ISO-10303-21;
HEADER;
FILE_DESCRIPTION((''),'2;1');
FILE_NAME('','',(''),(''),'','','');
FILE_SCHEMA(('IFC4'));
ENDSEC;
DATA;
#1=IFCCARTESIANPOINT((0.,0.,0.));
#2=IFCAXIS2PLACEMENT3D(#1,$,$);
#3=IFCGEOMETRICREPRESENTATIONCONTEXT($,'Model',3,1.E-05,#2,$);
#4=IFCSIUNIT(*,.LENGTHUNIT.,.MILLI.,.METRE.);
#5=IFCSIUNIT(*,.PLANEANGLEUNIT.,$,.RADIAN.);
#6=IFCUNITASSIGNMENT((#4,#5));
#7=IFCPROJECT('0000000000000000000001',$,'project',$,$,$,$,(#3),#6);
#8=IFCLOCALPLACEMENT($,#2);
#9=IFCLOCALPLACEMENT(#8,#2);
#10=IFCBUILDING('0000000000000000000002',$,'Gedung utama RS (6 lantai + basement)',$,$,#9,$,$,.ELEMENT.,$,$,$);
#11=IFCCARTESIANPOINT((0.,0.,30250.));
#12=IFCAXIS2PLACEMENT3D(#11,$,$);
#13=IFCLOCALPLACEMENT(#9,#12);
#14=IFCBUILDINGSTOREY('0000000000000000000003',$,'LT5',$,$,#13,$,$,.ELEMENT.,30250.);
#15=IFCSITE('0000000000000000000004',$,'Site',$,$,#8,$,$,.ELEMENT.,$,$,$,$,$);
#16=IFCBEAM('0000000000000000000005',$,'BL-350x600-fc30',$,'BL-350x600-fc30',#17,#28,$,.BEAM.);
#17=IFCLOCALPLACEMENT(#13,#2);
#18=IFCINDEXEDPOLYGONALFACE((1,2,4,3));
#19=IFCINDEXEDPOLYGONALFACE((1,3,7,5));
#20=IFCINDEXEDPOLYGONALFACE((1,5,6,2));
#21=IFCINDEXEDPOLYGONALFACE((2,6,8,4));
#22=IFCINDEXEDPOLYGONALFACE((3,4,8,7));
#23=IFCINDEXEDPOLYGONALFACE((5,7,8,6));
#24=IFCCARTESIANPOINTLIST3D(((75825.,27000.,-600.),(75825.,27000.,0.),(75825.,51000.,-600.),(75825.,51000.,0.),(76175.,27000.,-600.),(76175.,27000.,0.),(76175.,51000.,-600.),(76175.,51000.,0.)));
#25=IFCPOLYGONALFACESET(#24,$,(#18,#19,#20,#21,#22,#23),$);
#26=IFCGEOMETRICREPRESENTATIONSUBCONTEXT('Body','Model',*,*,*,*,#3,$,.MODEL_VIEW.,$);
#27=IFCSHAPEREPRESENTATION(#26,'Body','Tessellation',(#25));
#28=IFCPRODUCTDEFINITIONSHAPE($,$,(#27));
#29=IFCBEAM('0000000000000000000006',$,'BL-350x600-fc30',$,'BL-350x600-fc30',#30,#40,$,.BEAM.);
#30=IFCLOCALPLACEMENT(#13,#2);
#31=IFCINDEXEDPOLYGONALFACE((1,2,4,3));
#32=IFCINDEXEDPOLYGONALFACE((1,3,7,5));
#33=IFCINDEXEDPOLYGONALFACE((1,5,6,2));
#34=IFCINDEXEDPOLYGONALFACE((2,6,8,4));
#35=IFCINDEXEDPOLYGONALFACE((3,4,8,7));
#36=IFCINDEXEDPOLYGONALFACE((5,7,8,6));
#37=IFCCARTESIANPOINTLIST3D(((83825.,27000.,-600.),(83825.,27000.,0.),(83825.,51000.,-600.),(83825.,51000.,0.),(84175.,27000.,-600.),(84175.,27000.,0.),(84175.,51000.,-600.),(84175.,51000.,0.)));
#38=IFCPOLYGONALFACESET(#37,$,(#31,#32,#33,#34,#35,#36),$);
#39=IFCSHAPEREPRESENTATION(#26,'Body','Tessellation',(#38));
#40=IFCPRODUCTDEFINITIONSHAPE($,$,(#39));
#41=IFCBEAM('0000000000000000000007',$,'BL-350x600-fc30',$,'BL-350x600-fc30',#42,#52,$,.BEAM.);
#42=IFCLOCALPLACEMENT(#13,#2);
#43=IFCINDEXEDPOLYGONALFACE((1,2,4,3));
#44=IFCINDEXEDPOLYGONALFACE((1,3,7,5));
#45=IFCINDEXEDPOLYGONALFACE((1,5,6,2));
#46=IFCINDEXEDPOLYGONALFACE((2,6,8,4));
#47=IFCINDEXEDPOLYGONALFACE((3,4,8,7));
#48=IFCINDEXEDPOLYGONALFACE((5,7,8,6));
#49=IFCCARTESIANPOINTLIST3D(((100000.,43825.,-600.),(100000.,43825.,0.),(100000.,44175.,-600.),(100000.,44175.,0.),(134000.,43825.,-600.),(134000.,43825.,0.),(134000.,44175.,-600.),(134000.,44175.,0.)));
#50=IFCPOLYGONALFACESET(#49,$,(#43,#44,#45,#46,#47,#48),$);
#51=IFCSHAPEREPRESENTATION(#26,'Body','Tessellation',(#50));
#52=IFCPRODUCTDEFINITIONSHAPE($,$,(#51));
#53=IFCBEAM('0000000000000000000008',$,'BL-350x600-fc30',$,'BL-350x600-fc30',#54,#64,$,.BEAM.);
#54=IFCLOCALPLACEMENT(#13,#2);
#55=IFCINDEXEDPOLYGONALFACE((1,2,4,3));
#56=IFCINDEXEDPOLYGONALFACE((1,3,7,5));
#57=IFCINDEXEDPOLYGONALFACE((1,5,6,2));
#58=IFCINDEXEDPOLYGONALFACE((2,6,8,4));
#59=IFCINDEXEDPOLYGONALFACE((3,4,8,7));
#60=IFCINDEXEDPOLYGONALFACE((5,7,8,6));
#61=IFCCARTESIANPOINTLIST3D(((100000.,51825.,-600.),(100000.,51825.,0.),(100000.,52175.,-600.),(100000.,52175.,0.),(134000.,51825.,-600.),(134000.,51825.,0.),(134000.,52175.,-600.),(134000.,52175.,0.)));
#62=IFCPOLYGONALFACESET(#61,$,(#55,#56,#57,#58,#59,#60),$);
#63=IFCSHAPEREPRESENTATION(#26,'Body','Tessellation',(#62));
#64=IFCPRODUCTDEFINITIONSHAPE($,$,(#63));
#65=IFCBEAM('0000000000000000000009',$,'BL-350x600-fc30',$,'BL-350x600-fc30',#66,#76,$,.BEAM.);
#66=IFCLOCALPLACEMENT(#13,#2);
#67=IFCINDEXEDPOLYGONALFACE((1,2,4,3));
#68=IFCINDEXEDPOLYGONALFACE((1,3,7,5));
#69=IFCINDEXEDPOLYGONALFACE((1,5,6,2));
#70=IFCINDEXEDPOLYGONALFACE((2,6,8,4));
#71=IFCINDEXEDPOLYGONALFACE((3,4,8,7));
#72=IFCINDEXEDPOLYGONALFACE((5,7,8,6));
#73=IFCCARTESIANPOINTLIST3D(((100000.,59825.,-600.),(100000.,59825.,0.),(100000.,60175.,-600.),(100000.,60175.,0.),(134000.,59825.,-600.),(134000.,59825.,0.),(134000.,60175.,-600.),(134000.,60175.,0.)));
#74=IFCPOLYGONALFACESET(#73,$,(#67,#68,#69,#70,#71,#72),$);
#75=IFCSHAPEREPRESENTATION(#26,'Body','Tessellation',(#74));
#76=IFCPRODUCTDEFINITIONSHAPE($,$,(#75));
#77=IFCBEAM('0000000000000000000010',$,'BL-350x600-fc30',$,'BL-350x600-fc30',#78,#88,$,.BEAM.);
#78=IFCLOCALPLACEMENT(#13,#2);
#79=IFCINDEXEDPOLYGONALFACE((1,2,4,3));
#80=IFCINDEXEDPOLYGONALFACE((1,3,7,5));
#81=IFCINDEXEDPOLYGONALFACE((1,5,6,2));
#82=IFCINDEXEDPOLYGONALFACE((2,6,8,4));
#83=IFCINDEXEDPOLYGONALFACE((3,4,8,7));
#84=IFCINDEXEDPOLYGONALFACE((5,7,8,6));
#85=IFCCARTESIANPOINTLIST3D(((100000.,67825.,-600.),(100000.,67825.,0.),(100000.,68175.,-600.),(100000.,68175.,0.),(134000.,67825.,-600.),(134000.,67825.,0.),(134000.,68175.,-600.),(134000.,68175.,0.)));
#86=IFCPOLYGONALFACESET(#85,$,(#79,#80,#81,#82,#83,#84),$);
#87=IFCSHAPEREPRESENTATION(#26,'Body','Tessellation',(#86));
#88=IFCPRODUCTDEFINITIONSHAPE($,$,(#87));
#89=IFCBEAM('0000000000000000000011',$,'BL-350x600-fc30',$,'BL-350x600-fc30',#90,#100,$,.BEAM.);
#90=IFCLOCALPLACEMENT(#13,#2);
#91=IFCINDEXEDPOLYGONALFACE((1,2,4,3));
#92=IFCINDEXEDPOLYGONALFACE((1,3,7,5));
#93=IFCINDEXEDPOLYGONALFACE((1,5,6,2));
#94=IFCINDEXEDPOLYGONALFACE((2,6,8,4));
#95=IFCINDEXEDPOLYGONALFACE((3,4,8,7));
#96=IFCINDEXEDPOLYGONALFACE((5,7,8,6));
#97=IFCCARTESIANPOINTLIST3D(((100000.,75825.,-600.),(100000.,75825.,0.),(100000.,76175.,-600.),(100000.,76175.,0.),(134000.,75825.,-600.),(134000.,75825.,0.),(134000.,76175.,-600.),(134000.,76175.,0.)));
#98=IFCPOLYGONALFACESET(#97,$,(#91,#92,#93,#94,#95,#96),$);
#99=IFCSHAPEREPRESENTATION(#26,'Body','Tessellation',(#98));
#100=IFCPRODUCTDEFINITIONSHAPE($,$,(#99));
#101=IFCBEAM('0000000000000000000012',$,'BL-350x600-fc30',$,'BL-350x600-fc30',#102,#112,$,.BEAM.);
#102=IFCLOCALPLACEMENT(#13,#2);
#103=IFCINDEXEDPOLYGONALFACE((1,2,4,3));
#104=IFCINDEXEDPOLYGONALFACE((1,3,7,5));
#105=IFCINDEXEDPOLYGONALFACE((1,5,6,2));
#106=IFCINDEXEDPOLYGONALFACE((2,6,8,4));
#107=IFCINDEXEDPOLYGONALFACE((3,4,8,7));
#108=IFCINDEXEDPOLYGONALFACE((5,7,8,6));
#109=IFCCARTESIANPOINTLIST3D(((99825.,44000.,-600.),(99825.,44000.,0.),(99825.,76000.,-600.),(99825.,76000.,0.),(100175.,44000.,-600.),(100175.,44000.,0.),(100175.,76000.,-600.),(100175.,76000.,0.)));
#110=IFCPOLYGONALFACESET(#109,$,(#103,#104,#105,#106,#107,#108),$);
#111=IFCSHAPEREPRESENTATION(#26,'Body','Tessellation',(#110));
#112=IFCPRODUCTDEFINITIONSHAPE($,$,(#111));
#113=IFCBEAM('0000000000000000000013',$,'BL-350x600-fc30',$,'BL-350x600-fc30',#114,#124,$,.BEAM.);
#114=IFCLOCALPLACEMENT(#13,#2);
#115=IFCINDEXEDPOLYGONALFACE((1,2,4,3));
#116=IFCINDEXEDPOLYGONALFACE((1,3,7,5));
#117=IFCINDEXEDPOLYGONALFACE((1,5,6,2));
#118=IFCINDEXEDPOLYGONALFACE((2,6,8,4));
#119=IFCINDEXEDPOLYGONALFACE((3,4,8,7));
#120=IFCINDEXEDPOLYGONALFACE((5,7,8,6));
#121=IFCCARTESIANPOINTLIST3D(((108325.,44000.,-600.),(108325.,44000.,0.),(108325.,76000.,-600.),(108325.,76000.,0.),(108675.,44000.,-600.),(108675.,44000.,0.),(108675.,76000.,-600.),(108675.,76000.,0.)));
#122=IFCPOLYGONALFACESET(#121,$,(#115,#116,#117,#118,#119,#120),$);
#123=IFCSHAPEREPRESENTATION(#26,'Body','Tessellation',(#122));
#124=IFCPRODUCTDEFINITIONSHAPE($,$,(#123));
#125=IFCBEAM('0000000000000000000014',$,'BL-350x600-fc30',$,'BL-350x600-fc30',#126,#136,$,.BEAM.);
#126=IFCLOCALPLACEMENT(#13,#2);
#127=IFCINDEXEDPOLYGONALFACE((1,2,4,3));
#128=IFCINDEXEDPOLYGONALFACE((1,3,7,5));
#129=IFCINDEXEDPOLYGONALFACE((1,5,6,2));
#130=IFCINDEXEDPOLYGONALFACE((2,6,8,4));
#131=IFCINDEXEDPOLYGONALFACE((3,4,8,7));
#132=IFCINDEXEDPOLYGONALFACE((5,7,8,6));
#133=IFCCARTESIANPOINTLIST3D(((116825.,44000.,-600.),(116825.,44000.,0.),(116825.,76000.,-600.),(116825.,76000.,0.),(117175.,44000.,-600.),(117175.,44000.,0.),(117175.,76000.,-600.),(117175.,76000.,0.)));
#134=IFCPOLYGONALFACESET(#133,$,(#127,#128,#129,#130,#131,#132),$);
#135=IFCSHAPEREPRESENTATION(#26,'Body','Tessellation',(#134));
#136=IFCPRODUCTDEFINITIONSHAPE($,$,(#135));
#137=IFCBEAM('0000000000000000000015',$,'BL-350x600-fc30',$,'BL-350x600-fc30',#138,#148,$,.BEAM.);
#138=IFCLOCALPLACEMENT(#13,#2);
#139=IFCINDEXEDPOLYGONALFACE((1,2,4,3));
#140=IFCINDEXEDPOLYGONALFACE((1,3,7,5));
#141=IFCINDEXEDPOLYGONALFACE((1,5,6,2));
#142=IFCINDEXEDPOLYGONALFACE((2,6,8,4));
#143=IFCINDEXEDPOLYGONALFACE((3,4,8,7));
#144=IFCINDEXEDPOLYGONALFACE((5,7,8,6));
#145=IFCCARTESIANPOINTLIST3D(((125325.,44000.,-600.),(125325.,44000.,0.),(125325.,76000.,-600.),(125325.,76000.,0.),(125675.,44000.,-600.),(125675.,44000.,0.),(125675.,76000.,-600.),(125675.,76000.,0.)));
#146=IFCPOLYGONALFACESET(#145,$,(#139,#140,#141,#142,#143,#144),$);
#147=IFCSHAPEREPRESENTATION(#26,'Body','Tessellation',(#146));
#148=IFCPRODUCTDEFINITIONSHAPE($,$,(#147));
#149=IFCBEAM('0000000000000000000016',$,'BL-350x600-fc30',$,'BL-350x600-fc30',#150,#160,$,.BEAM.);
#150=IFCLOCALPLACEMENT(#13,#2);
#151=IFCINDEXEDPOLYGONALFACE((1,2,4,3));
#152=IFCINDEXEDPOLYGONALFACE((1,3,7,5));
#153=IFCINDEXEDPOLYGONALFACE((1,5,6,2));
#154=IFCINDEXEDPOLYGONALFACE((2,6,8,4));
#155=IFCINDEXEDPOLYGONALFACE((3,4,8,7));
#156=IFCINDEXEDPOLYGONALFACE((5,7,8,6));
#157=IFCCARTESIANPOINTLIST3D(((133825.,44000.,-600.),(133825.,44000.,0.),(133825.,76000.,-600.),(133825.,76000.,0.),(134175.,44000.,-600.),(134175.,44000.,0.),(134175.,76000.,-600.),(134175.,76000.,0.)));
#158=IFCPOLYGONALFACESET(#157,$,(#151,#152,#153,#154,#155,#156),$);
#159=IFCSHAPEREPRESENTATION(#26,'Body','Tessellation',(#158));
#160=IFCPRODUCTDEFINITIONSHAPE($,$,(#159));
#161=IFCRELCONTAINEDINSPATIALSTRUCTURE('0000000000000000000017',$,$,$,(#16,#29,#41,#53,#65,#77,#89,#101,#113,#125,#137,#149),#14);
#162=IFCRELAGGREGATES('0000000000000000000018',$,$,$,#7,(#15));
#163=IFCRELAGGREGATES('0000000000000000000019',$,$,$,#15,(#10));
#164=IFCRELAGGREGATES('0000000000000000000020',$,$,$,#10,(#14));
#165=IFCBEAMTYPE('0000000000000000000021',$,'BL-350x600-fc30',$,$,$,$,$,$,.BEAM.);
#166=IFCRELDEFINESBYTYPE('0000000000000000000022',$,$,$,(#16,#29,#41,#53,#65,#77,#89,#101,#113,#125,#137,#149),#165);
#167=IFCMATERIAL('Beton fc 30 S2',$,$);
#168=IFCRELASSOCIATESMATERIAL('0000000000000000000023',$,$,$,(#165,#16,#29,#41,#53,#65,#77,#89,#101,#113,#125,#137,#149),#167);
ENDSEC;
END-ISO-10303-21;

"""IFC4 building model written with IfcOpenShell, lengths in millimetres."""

from ifc_helpers import new_model, si_unit, frame, origin, origin_2d, place, context, subcontext, project, spatial, rectangle, extrude, material, material_profile, profile_set, profile_usage, type_object, element, save


model = new_model("IFC4")

# Units and contexts
model_context = context("Model", 3, precision=1e-05, world=origin())
body_context = subcontext(model_context, "Body", "Model", "MODEL_VIEW")
ifc_project = project(units=[si_unit("LENGTHUNIT", "METRE", prefix="MILLI"), si_unit("PLANEANGLEUNIT", "RADIAN")], contexts=[model_context])

# Site, building, storey
site_placement = place(None, origin())
site = spatial("IfcSite", under=ifc_project, at=site_placement, Name="Site", CompositionType="ELEMENT")
building_placement = place(site_placement, origin())
building = spatial("IfcBuilding", under=site, at=building_placement, Name="Gedung utama RS (6 lantai + basement)", CompositionType="ELEMENT")
storey_placement = place(building_placement, frame((0.0, 0.0, 30250.0)))
storey = spatial("IfcBuildingStorey", under=building, at=storey_placement, Name="LT5", CompositionType="ELEMENT", Elevation=30250.0)

# Beams
ifc_material = material(Name="Beton fc 30 S2")
ifc_material_profile_1 = material_profile(ifc_material, rectangle(XDim=350.0, YDim=600.0, at=origin_2d()), Name="BL-350x600-fc30")
ifc_profile_set_1 = profile_set([ifc_material_profile_1], Name="BL-350x600-fc30")
ifc_profile_usage_1 = profile_usage(ifc_profile_set_1, cardinal=8)
beam_type = type_object("IfcBeamType", Name="BL-350x600-fc30", PredefinedType="BEAM", material=ifc_profile_set_1)
for number, where, name in (
    (1, (76000.0, 27000.0, -300.0), "BL-350x600-fc30"),
    (2, (84000.0, 27000.0, -300.0), "BL-350x600-fc30"),
):
    element("IfcBeam", number, at=place(storey_placement, frame(where)), inside=storey, type_object=beam_type, material=ifc_profile_usage_1, Name=name, ObjectType="BL-350x600-fc30", PredefinedType="BEAM", context=body_context, shape_type="SweptSolid", body=[
        extrude(rectangle(XDim=350.0, YDim=600.0, at=origin_2d()), frame((0.0, 0.0, 0.0), z_axis=(0.0, 1.0, 0.0), x_axis=(-1.0, 0.0, 0.0)), (0.0, 0.0, 1.0), 24000.0),
    ])
for number, where, name in (
    (3, (100000.0, 44000.0, -300.0), "BL-350x600-fc30"),
    (4, (100000.0, 52000.0, -300.0), "BL-350x600-fc30"),
    (5, (100000.0, 60000.0, -300.0), "BL-350x600-fc30"),
    (6, (100000.0, 68000.0, -300.0), "BL-350x600-fc30"),
    (7, (100000.0, 76000.0, -300.0), "BL-350x600-fc30"),
):
    element("IfcBeam", number, at=place(storey_placement, frame(where)), inside=storey, type_object=beam_type, material=ifc_profile_usage_1, Name=name, ObjectType="BL-350x600-fc30", PredefinedType="BEAM", context=body_context, shape_type="SweptSolid", body=[
        extrude(rectangle(XDim=350.0, YDim=600.0, at=origin_2d()), frame((0.0, 0.0, 0.0), z_axis=(1.0, 0.0, 0.0), x_axis=(0.0, 1.0, 0.0)), (0.0, 0.0, 1.0), 34000.0),
    ])
for number, where, name in (
    (8, (100000.0, 44000.0, -300.0), "BL-350x600-fc30"),
    (9, (108500.0, 44000.0, -300.0), "BL-350x600-fc30"),
    (10, (117000.0, 44000.0, -300.0), "BL-350x600-fc30"),
    (11, (125500.0, 44000.0, -300.0), "BL-350x600-fc30"),
    (12, (134000.0, 44000.0, -300.0), "BL-350x600-fc30"),
):
    element("IfcBeam", number, at=place(storey_placement, frame(where)), inside=storey, type_object=beam_type, material=ifc_profile_usage_1, Name=name, ObjectType="BL-350x600-fc30", PredefinedType="BEAM", context=body_context, shape_type="SweptSolid", body=[
        extrude(rectangle(XDim=350.0, YDim=600.0, at=origin_2d()), frame((0.0, 0.0, 0.0), z_axis=(0.0, 1.0, 0.0), x_axis=(-1.0, 0.0, 0.0)), (0.0, 0.0, 1.0), 32000.0),
    ])

save(model, "model.ifc")
